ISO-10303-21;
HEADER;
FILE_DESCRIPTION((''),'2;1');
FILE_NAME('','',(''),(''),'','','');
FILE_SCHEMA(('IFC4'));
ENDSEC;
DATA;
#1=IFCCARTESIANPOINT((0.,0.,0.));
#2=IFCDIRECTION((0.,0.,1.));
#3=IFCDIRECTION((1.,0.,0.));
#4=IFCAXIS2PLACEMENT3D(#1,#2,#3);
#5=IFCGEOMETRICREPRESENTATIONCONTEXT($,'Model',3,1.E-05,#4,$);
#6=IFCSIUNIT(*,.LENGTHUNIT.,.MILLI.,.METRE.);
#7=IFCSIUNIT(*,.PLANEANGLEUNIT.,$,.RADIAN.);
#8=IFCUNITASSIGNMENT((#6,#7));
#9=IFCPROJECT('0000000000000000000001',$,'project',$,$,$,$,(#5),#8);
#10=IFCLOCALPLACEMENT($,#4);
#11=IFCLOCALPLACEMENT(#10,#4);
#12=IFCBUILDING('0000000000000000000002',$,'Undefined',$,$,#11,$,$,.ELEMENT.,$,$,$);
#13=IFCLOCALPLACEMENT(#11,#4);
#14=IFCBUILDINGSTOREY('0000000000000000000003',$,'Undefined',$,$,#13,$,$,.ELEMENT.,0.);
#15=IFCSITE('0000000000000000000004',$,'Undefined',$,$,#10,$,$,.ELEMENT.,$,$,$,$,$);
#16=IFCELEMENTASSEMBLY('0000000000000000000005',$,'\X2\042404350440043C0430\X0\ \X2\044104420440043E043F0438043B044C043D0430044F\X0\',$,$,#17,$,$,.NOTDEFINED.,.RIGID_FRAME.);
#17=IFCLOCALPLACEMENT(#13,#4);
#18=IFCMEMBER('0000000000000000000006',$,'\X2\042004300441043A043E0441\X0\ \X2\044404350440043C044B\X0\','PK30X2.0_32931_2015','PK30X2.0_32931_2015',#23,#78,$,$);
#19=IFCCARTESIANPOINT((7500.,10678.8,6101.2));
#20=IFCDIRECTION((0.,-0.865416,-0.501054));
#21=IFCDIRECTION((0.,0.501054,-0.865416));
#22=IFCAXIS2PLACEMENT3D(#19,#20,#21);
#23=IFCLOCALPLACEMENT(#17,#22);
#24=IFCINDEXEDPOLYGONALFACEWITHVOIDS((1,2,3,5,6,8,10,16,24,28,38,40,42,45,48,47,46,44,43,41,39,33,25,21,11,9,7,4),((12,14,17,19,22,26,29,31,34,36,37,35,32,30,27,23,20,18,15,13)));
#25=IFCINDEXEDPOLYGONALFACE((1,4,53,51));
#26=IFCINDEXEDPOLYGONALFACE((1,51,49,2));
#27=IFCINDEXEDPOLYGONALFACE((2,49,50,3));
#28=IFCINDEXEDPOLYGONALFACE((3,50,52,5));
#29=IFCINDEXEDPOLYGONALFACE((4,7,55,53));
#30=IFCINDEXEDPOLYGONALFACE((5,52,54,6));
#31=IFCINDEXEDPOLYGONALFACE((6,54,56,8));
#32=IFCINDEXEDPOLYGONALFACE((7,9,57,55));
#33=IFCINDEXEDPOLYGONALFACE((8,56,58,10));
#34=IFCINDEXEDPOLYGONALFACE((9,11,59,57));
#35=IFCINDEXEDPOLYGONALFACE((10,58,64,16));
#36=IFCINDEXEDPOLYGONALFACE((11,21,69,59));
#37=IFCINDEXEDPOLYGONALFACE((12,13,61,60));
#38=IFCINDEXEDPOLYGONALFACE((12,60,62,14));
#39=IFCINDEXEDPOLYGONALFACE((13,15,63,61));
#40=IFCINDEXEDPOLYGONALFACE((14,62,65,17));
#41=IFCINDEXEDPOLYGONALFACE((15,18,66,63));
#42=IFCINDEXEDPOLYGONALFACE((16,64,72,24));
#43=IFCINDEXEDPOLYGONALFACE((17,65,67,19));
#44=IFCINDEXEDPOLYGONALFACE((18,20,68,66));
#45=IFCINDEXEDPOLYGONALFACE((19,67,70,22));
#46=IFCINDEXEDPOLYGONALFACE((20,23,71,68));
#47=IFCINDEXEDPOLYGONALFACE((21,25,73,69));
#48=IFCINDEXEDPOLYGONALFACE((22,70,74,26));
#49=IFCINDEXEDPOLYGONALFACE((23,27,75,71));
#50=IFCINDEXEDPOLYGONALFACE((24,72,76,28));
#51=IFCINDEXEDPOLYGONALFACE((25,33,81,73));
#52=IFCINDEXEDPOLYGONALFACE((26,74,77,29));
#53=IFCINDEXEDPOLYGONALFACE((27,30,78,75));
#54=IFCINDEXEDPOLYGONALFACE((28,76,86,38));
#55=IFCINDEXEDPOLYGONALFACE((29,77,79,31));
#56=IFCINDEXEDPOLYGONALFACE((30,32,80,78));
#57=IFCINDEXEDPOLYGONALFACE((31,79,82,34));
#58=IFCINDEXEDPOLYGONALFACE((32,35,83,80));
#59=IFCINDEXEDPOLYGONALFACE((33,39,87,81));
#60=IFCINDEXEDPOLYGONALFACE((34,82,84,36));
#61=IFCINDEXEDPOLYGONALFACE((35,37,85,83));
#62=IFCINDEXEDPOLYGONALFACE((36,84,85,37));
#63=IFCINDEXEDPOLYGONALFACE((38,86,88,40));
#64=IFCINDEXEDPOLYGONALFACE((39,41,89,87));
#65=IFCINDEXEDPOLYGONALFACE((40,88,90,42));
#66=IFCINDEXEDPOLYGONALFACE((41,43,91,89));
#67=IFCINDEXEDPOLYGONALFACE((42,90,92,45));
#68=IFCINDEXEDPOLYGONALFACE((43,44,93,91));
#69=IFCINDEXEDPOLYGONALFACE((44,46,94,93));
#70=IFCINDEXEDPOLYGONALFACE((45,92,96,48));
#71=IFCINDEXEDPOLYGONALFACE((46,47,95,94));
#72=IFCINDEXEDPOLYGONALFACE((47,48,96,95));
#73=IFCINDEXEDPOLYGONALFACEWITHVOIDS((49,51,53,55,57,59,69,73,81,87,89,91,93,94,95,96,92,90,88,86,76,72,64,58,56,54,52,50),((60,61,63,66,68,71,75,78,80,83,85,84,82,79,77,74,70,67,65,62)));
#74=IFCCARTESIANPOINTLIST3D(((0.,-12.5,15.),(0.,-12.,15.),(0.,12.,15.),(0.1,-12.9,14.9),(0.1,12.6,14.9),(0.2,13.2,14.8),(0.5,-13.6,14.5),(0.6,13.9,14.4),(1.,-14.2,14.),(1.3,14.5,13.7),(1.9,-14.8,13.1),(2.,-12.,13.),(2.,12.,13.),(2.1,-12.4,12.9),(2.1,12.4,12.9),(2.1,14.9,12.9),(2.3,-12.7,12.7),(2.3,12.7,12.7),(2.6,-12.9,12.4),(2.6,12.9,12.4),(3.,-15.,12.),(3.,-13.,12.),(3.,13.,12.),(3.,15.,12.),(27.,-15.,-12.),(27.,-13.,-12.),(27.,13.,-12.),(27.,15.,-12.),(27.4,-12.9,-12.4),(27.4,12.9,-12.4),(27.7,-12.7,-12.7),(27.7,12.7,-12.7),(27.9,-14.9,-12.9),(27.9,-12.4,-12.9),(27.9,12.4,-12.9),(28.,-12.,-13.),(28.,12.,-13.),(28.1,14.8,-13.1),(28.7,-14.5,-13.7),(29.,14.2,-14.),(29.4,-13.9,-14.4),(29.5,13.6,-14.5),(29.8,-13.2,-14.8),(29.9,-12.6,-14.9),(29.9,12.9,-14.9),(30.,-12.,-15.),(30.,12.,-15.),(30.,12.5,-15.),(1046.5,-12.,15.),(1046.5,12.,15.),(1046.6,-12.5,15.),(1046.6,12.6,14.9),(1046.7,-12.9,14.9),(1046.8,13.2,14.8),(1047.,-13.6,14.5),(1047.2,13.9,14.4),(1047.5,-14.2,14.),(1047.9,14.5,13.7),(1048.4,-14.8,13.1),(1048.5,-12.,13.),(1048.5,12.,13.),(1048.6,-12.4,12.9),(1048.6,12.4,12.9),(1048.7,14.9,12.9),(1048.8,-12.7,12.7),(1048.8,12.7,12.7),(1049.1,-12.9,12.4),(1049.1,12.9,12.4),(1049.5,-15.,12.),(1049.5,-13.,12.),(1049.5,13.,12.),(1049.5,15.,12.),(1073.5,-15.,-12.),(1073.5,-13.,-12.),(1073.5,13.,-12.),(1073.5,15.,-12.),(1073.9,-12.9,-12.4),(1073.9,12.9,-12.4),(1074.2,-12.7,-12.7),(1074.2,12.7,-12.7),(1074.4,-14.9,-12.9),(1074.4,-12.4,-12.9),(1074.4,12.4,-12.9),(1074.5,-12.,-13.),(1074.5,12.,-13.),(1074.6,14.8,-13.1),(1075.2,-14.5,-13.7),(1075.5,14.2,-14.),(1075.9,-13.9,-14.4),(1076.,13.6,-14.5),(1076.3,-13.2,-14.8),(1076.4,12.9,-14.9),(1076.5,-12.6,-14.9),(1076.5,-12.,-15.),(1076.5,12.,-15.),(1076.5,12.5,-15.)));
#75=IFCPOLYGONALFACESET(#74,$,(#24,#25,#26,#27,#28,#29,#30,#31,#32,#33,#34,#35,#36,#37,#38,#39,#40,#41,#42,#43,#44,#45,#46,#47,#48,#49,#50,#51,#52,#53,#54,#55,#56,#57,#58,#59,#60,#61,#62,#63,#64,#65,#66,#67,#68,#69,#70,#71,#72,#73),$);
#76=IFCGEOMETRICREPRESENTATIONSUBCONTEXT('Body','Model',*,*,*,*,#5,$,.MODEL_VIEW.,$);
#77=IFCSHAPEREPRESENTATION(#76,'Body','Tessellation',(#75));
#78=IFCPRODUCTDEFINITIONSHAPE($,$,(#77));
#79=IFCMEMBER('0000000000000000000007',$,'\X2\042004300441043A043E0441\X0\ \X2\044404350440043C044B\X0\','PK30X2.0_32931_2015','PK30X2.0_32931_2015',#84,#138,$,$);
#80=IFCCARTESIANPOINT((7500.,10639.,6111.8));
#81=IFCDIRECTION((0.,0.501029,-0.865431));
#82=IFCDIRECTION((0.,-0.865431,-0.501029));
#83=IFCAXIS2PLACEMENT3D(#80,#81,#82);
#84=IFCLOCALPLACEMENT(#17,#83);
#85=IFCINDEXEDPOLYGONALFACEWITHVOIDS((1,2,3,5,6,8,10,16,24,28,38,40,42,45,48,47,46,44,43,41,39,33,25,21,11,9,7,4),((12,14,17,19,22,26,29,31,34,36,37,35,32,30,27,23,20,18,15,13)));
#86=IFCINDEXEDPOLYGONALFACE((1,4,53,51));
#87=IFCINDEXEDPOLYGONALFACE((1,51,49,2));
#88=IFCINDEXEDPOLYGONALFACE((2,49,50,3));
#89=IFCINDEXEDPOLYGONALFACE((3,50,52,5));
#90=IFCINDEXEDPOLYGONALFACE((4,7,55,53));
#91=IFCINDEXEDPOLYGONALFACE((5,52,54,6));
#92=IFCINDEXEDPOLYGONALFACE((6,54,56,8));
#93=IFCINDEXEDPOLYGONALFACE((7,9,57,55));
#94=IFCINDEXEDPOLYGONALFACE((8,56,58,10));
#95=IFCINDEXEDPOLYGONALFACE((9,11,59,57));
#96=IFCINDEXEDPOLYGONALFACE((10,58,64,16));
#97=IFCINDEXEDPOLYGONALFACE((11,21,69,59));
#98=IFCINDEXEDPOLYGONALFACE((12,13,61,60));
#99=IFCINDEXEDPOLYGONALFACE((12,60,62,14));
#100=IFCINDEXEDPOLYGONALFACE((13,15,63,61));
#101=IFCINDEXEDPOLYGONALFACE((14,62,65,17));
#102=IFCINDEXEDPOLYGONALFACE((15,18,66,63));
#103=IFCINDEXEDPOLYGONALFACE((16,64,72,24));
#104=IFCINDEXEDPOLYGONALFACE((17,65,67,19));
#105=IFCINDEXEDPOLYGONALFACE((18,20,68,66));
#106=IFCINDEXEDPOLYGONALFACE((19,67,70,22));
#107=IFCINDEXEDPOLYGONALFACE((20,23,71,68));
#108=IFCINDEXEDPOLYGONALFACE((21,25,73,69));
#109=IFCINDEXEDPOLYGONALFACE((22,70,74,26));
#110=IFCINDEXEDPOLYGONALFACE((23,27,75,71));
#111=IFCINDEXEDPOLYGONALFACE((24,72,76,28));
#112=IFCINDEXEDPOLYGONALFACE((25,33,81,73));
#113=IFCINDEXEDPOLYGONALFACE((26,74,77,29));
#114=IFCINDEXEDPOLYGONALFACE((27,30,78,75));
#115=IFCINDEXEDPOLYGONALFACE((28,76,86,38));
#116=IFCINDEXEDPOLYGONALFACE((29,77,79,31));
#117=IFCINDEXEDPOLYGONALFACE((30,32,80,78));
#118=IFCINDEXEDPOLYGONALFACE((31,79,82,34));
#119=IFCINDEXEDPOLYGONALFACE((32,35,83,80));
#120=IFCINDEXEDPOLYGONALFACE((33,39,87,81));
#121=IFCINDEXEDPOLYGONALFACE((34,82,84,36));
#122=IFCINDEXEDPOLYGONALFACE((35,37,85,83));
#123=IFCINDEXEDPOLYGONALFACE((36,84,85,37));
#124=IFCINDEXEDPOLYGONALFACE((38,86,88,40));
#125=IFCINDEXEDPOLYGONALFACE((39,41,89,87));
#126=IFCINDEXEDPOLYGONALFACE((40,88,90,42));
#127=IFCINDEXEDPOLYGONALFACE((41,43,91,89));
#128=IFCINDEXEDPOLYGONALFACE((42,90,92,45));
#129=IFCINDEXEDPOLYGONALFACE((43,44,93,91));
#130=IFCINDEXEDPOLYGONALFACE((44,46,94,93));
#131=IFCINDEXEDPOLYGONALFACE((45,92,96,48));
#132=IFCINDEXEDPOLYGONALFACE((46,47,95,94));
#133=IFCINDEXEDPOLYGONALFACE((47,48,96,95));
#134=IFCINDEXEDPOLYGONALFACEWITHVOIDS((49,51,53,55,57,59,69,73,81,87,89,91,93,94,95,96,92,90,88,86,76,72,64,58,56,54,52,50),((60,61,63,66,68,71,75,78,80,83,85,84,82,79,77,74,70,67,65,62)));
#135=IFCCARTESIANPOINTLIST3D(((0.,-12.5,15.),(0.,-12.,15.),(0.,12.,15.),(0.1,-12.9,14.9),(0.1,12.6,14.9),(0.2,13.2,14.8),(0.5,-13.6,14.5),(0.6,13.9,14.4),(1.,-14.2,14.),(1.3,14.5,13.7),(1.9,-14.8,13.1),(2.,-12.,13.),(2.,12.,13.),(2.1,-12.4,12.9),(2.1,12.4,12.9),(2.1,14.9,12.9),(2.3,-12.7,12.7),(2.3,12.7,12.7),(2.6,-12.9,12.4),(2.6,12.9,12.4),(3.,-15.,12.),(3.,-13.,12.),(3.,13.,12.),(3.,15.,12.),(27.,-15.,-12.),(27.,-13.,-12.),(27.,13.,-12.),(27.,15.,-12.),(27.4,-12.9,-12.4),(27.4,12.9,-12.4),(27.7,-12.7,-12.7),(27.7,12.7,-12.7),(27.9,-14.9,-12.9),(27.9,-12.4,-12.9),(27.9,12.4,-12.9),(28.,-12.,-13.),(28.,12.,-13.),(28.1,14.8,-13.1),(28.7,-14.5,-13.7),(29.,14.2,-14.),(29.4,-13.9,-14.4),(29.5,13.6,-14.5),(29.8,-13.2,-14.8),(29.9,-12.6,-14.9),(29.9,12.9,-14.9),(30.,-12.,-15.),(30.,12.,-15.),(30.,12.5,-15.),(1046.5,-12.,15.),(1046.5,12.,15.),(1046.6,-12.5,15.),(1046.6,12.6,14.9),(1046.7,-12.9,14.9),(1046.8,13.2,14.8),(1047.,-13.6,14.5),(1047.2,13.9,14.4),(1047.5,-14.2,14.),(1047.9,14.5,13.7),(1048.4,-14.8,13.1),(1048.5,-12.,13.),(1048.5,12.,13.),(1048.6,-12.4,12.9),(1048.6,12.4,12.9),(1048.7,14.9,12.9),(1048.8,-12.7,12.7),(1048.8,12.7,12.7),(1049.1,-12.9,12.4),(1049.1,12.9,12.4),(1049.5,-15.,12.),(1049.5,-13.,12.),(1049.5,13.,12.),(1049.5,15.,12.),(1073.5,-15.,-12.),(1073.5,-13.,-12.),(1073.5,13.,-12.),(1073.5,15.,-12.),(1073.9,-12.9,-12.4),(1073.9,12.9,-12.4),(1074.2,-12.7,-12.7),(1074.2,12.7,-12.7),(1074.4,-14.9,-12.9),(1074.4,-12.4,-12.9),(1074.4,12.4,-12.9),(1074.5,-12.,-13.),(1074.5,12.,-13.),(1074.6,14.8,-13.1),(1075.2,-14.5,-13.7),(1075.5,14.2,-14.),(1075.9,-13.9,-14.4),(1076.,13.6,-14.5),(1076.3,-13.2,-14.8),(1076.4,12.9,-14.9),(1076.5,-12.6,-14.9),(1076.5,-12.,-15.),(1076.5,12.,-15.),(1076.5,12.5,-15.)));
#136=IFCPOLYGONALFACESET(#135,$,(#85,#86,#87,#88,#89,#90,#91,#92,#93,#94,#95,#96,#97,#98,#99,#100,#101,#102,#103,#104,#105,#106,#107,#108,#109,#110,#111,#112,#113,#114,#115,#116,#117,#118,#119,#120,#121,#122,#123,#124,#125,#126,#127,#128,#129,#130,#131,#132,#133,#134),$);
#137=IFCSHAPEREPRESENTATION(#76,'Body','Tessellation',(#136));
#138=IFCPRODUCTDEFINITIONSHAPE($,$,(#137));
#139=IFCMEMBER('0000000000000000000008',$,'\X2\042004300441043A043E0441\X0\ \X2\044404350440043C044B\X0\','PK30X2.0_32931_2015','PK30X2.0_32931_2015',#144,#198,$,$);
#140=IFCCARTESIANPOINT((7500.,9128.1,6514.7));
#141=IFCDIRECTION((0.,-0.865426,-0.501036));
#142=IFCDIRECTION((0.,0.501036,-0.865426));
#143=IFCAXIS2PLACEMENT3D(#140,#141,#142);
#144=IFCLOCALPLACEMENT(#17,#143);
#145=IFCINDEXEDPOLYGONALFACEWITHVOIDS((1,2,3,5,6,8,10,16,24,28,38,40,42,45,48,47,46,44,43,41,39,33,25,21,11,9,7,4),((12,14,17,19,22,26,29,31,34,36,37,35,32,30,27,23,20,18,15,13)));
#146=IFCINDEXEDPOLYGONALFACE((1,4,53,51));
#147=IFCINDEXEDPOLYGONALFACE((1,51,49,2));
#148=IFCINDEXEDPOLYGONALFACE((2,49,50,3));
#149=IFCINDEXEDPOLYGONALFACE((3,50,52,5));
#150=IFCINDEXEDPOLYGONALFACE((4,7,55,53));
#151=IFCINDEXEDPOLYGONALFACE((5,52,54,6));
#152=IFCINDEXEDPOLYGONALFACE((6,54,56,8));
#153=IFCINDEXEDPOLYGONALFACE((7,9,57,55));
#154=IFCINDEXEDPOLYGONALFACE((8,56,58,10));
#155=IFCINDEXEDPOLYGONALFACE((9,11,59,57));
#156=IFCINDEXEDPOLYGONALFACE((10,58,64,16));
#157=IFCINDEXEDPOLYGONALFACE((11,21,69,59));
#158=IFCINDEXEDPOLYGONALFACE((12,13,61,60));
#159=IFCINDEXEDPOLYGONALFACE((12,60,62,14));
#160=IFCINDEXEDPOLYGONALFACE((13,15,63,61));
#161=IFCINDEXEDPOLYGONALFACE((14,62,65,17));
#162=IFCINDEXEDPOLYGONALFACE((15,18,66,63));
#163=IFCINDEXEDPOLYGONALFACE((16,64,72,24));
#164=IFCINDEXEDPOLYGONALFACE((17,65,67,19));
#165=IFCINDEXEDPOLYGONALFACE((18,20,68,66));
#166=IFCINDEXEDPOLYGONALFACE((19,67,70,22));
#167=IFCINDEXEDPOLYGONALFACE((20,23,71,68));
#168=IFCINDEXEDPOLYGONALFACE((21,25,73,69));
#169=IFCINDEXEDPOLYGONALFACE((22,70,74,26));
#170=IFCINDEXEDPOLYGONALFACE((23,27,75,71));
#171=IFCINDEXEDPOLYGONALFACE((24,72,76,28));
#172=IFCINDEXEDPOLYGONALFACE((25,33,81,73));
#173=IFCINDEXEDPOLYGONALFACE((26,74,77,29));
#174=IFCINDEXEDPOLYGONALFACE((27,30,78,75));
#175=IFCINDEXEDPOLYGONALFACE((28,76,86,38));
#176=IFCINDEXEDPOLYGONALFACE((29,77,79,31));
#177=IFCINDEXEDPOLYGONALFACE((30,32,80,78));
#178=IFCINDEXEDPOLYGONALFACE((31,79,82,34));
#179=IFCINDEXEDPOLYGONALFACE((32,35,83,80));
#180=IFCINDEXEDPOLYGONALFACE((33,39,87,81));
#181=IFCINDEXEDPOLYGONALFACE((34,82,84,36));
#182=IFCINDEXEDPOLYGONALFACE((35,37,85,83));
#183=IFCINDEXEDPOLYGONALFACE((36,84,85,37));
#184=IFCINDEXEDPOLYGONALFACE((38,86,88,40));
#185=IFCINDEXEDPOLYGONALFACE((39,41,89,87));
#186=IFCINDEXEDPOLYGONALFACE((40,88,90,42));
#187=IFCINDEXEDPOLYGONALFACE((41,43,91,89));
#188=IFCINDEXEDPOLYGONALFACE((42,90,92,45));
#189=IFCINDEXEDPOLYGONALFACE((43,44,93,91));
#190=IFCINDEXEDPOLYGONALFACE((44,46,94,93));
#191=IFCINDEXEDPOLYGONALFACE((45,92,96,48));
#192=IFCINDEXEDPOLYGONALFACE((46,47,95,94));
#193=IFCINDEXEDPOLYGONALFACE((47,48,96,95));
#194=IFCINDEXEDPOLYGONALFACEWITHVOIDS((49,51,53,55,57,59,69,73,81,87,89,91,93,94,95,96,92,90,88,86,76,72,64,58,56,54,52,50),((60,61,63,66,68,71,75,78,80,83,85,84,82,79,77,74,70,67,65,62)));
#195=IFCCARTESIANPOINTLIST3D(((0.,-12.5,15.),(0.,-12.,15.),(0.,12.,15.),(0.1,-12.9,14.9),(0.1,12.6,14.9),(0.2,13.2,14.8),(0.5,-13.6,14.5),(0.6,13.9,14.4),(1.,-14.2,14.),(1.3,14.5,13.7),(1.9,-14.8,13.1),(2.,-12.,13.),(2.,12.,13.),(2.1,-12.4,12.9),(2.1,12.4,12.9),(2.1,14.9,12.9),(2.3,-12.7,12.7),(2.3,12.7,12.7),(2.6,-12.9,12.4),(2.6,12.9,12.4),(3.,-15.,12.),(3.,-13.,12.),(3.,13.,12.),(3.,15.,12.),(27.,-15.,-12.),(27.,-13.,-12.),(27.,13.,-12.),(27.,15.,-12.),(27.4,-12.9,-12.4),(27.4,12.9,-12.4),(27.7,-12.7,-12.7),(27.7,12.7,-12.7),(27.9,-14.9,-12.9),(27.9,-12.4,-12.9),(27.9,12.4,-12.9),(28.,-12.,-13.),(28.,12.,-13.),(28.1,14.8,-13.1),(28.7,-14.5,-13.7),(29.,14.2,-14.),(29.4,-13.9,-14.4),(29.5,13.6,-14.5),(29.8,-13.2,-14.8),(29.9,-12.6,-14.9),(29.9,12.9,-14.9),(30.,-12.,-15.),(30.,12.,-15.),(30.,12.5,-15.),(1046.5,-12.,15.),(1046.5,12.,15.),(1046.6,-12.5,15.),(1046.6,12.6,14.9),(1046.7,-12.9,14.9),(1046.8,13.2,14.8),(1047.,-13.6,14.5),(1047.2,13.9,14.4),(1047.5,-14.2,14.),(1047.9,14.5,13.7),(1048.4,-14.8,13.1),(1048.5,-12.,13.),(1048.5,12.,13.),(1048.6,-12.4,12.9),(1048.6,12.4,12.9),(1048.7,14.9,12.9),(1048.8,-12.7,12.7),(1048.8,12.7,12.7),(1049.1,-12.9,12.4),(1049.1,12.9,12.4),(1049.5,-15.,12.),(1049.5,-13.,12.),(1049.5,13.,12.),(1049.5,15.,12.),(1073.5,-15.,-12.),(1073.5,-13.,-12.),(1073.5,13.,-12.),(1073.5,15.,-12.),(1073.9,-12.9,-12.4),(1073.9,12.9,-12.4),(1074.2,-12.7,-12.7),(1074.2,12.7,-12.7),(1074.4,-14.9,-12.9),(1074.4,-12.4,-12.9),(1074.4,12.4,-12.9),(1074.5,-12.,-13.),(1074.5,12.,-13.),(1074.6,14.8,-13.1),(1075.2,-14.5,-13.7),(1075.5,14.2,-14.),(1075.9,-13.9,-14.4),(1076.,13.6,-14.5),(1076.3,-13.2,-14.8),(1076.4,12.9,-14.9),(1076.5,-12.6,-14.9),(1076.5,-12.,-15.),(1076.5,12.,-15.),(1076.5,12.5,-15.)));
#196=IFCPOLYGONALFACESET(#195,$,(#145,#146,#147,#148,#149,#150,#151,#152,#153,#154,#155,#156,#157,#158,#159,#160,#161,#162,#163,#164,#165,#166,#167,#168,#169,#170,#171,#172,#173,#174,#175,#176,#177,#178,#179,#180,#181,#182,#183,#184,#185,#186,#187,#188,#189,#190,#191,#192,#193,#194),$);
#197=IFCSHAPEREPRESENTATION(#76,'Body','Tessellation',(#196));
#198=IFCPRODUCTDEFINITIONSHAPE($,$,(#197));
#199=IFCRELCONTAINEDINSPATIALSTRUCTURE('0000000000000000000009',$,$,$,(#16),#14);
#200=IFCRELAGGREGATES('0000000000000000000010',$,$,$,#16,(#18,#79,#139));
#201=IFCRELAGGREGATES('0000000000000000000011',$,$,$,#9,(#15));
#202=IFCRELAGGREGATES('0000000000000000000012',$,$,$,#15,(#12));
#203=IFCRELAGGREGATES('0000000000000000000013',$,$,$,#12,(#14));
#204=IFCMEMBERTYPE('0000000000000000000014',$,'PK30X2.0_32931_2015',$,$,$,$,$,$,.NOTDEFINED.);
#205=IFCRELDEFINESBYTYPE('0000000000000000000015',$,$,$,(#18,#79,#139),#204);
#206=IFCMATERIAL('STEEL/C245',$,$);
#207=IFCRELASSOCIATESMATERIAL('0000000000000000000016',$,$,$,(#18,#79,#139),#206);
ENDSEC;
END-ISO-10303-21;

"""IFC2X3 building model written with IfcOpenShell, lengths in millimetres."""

from ifc_helpers import new_model, si_unit, frame, origin_with_axes, origin_2d_with_axis, place, context, subcontext, project, spatial, hollow_rectangle, extrude, clip, halfspace, material, type_object, element, aggregate, save


model = new_model("IFC2X3")

# Units and contexts
model_context = context("Model", 3, precision=1e-05, world=origin_with_axes())
body_context = subcontext(model_context, "Body", "Model", "MODEL_VIEW")
ifc_project = project(units=[si_unit("LENGTHUNIT", "METRE", prefix="MILLI"), si_unit("PLANEANGLEUNIT", "RADIAN")], contexts=[model_context])

# Site, building, storey
site_placement = place(None, origin_with_axes())
site = spatial("IfcSite", under=ifc_project, at=site_placement, Name="Undefined", CompositionType="ELEMENT")
building_placement = place(site_placement, origin_with_axes())
building = spatial("IfcBuilding", under=site, at=building_placement, Name="Undefined", CompositionType="ELEMENT")
storey_placement = place(building_placement, origin_with_axes())
storey = spatial("IfcBuildingStorey", under=building, at=storey_placement, Name="Undefined", CompositionType="ELEMENT", Elevation=0.0)

# Element assembly
assembly_1_placement = place(storey_placement, origin_with_axes())
assembly_1 = element("IfcElementAssembly", 1, at=assembly_1_placement, inside=storey, Name="Ферма стропильная", AssemblyPlace="NOTDEFINED", PredefinedType="RIGID_FRAME")
ifc_material_1 = material(Name="STEEL/C245")

# Members
member_type = type_object("IfcMemberType", Name="PK30X2.0_32931_2015", PredefinedType="NOTDEFINED")
member_1_placement = place(assembly_1_placement, frame((7500.0, 10678.8, 6101.2), z_axis=(0.0, -0.865416, -0.501054), x_axis=(0.0, 0.501054, -0.865416)))
member_1 = element("IfcMember", 2, at=member_1_placement, type_object=member_type, material=ifc_material_1, Name="Раскос фермы", Description="PK30X2.0_32931_2015", ObjectType="PK30X2.0_32931_2015", context=body_context, shape_type="Clipping", body=[
    clip(clip(extrude(hollow_rectangle(XDim=30.0, YDim=30.0, WallThickness=2.0, InnerFilletRadius=1.0, OuterFilletRadius=3.0, at=origin_2d_with_axis()), frame((1091.8, 0.0, 0.0), z_axis=(-1.0, 0.0, 0.0), x_axis=(0.0, -1.0, 0.0)), (0.0, 0.0, 1.0), 1107.1), halfspace(frame((1060.0, 0.0, 1.5), z_axis=(-0.707107, 0.0, -0.707107), x_axis=(0.707107, 0.0, -0.707107)), True)), halfspace(frame((34.5, 0.0, -19.5), z_axis=(-0.707107, 0.0, -0.707107), x_axis=(0.707107, 0.0, -0.707107)), False)),
])
member_2_placement = place(assembly_1_placement, frame((7500.0, 10639.0, 6111.8), z_axis=(0.0, 0.501029, -0.865431), x_axis=(0.0, -0.865431, -0.501029)))
member_2 = element("IfcMember", 3, at=member_2_placement, type_object=member_type, material=ifc_material_1, Name="Раскос фермы", Description="PK30X2.0_32931_2015", ObjectType="PK30X2.0_32931_2015", context=body_context, shape_type="Clipping", body=[
    clip(clip(extrude(hollow_rectangle(XDim=30.0, YDim=30.0, WallThickness=2.0, InnerFilletRadius=1.0, OuterFilletRadius=3.0, at=origin_2d_with_axis()), frame((1102.9, 0.0, 0.0), z_axis=(-1.0, 0.0, 0.0), x_axis=(0.0, -1.0, 0.0)), (0.0, 0.0, 1.0), 1129.2), halfspace(frame((1060.0, 0.0, 1.5), z_axis=(-0.707107, 0.0, -0.707107), x_axis=(0.707107, 0.0, -0.707107)), True)), halfspace(frame((34.5, 0.0, -19.5), z_axis=(-0.707107, 0.0, -0.707107), x_axis=(0.707107, 0.0, -0.707107)), False)),
])
member_3_placement = place(assembly_1_placement, frame((7500.0, 9128.1, 6514.7), z_axis=(0.0, -0.865426, -0.501036), x_axis=(0.0, 0.501036, -0.865426)))
member_3 = element("IfcMember", 4, at=member_3_placement, type_object=member_type, material=ifc_material_1, Name="Раскос фермы", Description="PK30X2.0_32931_2015", ObjectType="PK30X2.0_32931_2015", context=body_context, shape_type="Clipping", body=[
    clip(clip(extrude(hollow_rectangle(XDim=30.0, YDim=30.0, WallThickness=2.0, InnerFilletRadius=1.0, OuterFilletRadius=3.0, at=origin_2d_with_axis()), frame((1091.8, 0.0, 0.0), z_axis=(-1.0, 0.0, 0.0), x_axis=(0.0, -1.0, 0.0)), (0.0, 0.0, 1.0), 1107.1), halfspace(frame((1060.0, 0.0, 1.5), z_axis=(-0.707107, 0.0, -0.707107), x_axis=(0.707107, 0.0, -0.707107)), True)), halfspace(frame((34.5, 0.0, -19.5), z_axis=(-0.707107, 0.0, -0.707107), x_axis=(0.707107, 0.0, -0.707107)), False)),
])
aggregate(assembly_1, [member_1, member_2, member_3])

save(model, "model.ifc")
